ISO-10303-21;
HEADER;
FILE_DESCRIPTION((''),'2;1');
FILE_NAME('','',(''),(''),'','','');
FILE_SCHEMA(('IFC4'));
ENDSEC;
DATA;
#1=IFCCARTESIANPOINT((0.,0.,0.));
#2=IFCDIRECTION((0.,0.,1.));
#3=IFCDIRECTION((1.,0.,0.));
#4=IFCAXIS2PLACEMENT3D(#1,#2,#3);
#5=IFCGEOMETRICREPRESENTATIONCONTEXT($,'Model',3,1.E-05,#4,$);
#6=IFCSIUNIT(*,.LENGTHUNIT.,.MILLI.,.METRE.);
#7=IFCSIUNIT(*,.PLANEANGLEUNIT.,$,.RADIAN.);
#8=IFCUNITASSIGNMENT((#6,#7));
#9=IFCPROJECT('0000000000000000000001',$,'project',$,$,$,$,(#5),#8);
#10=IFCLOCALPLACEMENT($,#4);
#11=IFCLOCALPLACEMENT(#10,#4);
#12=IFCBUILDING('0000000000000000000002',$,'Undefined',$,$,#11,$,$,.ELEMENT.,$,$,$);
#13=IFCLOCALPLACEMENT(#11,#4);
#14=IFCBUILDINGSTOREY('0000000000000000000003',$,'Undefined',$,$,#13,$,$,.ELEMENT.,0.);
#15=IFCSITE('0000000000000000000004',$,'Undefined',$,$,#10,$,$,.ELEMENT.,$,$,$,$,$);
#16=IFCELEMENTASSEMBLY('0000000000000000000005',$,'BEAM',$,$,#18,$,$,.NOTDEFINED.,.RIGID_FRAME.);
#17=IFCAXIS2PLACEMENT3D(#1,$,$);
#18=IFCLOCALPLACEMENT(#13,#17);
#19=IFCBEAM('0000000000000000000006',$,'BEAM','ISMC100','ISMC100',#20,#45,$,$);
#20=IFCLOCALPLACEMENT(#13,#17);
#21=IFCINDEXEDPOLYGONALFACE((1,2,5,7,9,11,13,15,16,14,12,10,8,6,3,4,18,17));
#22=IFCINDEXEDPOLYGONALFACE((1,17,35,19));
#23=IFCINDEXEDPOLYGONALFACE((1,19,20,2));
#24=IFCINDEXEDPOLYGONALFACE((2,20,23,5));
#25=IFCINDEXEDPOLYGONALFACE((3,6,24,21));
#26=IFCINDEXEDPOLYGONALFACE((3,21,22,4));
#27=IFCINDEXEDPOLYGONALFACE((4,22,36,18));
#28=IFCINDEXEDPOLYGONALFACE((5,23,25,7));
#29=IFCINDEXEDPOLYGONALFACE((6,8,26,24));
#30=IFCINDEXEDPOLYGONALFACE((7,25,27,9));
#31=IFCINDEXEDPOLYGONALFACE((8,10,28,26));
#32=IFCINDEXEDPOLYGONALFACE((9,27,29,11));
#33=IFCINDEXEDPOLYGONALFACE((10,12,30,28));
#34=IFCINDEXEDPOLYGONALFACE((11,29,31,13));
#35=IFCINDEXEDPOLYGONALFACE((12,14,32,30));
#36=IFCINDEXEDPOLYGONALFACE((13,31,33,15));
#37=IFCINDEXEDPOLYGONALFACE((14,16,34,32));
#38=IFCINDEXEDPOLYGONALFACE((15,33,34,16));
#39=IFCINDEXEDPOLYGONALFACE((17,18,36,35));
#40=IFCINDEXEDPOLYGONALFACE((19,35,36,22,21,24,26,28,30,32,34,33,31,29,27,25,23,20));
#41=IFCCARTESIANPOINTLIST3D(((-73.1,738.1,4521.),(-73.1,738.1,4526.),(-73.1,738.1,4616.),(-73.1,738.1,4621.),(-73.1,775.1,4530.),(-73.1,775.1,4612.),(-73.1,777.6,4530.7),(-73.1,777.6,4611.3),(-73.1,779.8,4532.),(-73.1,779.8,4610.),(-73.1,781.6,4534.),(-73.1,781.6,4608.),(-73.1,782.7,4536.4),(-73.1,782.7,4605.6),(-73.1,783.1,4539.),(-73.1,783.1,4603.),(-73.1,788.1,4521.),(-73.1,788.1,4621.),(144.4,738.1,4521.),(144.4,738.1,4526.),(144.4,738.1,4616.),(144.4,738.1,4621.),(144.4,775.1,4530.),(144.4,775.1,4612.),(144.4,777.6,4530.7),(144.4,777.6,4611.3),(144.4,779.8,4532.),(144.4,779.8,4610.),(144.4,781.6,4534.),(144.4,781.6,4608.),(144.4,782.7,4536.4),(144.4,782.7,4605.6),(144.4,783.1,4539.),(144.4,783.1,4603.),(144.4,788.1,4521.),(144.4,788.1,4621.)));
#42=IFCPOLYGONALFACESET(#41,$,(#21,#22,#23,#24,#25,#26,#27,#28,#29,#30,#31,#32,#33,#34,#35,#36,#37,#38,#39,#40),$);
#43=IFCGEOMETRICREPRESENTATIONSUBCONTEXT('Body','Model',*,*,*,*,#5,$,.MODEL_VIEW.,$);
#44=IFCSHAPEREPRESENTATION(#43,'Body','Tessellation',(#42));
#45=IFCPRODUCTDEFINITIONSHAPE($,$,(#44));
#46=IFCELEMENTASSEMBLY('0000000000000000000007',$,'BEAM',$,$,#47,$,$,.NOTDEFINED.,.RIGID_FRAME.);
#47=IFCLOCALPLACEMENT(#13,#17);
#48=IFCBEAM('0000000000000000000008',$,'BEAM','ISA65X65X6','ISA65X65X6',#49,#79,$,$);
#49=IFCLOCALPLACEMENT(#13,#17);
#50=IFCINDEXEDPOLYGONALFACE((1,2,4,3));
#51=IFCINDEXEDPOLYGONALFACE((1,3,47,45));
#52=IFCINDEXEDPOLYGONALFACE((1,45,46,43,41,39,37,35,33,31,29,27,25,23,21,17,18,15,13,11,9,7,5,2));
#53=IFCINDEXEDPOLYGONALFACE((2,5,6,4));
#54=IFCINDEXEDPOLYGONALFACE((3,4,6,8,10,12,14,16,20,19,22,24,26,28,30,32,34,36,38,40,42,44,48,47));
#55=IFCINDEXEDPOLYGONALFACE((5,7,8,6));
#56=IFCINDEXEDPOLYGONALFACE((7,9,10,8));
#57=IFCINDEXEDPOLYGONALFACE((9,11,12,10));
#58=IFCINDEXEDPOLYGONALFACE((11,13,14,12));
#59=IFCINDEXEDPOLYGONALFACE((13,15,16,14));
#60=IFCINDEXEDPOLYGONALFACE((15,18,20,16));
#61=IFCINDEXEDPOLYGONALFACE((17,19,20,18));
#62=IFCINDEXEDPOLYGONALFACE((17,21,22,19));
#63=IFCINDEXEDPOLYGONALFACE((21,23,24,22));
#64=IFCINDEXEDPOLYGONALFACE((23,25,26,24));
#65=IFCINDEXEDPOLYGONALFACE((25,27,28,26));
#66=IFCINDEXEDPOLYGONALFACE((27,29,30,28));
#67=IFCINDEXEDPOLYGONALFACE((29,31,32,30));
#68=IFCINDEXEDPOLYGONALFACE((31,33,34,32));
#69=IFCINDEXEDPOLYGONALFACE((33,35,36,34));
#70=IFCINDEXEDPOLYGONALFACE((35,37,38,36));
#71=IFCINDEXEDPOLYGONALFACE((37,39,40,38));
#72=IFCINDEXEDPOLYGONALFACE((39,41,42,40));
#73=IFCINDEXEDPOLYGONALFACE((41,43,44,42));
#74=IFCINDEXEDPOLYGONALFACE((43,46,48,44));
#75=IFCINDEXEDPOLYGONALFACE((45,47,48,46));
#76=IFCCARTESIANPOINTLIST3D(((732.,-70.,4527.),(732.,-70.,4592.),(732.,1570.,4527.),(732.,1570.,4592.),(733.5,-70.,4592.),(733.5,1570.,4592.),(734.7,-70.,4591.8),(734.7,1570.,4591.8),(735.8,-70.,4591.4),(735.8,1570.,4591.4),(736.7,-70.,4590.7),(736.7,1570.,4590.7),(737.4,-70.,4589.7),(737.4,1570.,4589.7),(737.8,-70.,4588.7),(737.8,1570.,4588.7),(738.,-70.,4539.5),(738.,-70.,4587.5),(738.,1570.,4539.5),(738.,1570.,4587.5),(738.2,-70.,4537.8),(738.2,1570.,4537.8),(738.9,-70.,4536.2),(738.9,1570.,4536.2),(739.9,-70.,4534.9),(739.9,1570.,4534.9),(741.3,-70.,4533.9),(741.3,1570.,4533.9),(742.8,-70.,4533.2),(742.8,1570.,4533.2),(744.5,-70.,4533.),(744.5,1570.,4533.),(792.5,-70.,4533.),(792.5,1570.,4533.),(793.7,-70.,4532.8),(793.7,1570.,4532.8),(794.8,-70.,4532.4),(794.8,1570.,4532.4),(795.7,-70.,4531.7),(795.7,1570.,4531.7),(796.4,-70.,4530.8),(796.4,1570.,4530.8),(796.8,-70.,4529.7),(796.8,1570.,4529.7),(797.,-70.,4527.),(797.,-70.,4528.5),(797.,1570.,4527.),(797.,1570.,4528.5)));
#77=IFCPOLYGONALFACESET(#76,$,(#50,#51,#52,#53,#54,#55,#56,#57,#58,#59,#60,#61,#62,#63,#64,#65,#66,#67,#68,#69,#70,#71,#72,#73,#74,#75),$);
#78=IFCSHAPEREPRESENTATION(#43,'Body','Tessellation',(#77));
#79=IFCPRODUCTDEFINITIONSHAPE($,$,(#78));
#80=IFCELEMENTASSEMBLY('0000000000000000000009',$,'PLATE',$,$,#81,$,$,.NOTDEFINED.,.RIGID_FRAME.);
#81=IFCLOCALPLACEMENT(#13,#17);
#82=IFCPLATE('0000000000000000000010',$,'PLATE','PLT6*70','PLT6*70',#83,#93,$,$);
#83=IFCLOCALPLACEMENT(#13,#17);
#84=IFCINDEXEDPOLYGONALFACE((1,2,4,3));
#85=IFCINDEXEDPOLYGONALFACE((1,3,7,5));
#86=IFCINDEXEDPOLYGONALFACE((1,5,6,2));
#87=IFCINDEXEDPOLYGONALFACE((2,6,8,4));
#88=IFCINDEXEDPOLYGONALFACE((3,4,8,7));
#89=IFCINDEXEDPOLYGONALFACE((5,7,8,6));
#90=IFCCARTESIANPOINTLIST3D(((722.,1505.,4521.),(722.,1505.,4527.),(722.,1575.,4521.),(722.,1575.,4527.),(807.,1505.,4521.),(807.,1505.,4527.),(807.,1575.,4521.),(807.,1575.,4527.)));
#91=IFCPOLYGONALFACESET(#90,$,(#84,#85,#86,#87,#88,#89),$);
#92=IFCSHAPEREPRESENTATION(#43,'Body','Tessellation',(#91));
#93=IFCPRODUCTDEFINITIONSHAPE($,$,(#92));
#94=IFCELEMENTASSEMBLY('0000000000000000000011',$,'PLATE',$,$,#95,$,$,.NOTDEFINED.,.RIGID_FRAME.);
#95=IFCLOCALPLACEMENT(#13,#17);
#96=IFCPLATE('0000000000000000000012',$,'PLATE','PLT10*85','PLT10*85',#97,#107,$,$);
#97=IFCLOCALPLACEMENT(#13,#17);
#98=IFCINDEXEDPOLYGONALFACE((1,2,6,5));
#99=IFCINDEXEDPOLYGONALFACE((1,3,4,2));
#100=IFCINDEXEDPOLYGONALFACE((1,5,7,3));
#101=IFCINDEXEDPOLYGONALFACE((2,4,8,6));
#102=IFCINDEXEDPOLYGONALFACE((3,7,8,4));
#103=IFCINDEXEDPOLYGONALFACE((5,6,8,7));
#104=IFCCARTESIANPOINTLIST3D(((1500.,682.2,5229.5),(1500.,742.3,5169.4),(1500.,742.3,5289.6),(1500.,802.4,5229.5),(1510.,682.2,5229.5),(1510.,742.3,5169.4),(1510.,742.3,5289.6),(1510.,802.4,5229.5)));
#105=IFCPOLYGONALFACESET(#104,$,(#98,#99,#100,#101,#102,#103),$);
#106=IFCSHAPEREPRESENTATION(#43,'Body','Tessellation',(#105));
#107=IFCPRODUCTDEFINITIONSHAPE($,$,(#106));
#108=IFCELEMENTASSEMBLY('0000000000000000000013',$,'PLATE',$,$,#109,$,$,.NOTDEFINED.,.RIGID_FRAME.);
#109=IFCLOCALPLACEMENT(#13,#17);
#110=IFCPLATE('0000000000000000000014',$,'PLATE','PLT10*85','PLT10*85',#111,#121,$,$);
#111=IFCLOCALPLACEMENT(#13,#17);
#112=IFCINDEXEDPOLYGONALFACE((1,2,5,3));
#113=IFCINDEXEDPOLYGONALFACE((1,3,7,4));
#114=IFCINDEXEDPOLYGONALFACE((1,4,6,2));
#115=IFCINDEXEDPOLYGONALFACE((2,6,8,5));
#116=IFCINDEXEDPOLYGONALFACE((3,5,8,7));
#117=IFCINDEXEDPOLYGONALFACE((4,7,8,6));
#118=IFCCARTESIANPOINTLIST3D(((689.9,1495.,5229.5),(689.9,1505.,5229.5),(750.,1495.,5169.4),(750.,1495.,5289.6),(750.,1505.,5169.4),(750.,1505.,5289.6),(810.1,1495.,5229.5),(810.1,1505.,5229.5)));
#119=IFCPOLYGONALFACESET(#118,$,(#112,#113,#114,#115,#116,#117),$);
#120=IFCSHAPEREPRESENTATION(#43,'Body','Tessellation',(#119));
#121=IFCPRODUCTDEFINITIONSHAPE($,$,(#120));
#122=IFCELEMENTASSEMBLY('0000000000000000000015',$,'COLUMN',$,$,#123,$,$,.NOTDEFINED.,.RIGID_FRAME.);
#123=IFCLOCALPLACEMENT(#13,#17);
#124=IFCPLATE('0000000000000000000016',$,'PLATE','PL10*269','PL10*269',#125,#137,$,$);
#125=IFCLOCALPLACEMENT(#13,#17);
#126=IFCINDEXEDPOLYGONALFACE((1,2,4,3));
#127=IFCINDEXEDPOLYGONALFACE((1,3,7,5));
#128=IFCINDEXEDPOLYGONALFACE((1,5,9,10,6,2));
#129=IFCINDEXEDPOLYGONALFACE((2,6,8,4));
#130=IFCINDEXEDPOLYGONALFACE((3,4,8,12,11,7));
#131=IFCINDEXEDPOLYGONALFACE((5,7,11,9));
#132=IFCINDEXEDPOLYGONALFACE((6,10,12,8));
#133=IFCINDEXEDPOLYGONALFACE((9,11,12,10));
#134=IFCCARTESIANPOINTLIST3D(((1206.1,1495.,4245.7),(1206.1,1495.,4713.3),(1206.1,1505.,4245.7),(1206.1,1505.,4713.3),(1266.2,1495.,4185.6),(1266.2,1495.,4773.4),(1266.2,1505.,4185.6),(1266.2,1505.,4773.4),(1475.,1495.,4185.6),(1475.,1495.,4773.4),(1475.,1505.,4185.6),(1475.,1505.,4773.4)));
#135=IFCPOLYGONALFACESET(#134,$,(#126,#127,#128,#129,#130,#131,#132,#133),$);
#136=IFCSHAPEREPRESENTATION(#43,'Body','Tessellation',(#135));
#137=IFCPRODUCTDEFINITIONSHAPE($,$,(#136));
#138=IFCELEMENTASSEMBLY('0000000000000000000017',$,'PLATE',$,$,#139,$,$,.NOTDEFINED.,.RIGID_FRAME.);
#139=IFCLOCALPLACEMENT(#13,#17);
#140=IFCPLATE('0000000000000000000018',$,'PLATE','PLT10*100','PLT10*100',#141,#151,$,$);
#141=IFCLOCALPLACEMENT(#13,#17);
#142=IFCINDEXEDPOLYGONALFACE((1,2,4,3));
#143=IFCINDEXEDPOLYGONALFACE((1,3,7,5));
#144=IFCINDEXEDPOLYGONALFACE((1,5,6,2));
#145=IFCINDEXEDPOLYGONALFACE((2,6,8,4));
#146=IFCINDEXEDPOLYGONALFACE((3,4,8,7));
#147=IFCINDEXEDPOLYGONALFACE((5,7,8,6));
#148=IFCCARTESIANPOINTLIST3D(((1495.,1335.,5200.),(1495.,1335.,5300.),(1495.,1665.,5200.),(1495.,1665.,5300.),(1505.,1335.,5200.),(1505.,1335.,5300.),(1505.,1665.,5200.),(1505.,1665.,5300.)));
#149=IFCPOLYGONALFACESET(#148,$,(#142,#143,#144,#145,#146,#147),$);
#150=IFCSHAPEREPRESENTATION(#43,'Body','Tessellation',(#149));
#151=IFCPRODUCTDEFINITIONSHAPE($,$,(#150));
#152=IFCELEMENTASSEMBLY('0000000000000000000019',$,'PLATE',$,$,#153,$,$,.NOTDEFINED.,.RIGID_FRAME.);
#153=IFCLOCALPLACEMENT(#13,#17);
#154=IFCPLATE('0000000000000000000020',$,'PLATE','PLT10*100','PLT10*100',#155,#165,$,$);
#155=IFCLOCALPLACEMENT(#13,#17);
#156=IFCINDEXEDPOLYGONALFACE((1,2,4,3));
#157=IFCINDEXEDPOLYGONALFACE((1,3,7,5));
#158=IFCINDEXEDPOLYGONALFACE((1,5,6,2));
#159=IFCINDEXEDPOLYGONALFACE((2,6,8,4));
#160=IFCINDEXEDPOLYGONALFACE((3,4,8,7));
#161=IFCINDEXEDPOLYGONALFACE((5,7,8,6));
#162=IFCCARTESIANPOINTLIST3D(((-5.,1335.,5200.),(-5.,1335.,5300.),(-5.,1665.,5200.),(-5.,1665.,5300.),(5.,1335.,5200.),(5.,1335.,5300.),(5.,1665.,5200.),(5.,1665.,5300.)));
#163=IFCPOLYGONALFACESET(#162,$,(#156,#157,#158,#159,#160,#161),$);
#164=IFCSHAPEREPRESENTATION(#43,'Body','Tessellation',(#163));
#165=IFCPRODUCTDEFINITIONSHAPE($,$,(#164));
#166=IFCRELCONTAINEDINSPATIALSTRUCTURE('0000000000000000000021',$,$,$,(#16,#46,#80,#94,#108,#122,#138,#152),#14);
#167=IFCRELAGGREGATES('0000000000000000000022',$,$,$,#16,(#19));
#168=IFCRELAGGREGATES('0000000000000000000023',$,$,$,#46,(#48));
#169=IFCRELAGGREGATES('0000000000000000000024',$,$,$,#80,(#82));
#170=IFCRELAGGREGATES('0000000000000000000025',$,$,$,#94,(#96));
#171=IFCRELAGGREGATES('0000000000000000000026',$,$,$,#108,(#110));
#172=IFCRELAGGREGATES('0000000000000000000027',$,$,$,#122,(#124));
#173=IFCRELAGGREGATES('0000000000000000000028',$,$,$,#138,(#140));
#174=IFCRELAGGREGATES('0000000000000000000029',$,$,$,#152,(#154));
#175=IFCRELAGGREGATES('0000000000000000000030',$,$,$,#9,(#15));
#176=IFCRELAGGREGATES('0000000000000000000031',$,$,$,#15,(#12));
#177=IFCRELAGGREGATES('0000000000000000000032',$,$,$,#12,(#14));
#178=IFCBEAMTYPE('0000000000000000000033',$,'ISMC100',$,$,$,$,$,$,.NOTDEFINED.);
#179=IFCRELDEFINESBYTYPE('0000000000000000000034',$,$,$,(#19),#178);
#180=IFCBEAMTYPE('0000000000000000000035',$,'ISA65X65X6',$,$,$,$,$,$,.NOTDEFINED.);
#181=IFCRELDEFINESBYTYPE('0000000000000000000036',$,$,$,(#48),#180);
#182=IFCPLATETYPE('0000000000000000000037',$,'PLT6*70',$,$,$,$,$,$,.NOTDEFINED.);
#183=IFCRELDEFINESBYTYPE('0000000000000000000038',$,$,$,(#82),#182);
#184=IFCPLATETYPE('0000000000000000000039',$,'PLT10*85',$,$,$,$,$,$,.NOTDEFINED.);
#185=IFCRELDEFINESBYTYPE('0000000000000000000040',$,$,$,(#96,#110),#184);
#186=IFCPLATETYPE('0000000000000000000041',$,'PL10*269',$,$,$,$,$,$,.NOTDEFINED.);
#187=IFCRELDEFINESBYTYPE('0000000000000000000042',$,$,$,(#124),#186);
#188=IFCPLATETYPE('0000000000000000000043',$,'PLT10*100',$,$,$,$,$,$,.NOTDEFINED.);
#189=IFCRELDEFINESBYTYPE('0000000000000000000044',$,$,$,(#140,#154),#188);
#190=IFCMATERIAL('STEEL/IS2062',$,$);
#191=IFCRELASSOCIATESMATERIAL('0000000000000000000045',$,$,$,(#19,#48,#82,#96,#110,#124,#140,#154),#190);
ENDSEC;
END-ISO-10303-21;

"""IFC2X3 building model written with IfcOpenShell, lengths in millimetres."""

from ifc_helpers import new_model, si_unit, frame, origin_with_axes, origin_2d_with_axis, place, context, subcontext, project, spatial, polyline, l_section, u_section, outline, extrude, material, type_object, element, aggregate, save


model = new_model("IFC2X3")

# Units and contexts
model_context = context("Model", 3, precision=1e-05, world=origin_with_axes())
body_context = subcontext(model_context, "Body", "Model", "MODEL_VIEW")
ifc_project = project(units=[si_unit("LENGTHUNIT", "METRE", prefix="MILLI"), si_unit("PLANEANGLEUNIT", "RADIAN")], contexts=[model_context])

# Site, building, storey
site_placement = place(None, origin_with_axes())
site = spatial("IfcSite", under=ifc_project, at=site_placement, Name="Undefined", CompositionType="ELEMENT")
building_placement = place(site_placement, origin_with_axes())
building = spatial("IfcBuilding", under=site, at=building_placement, Name="Undefined", CompositionType="ELEMENT")
storey_placement = place(building_placement, origin_with_axes())
storey = spatial("IfcBuildingStorey", under=building, at=storey_placement, Name="Undefined", CompositionType="ELEMENT", Elevation=0.0)

# Shared definitions
ifc_material = material(Name="STEEL/IS2062")

# Element assemblies, beams
beam_type_1 = type_object("IfcBeamType", Name="ISMC100", PredefinedType="NOTDEFINED")
assembly_1_placement = place(storey_placement, origin_with_axes())
assembly_1 = element("IfcElementAssembly", 1, at=assembly_1_placement, inside=storey, Name="BEAM", AssemblyPlace="NOTDEFINED", PredefinedType="RIGID_FRAME")
beam_1_placement = place(assembly_1_placement, frame((144.4, 763.1, 4571.0), z_axis=(0.0, 0.0, -1.0), x_axis=(-1.0, 0.0, 0.0)))
beam_1 = element("IfcBeam", 2, at=beam_1_placement, type_object=beam_type_1, material=ifc_material, Name="BEAM", Description="ISMC100", ObjectType="ISMC100", context=body_context, shape_type="SweptSolid", body=[
    extrude(u_section(Depth=100.0, FlangeWidth=50.0, WebThickness=5.0, FlangeThickness=7.7, FilletRadius=9.0, FlangeSlope=0.10956, at=origin_2d_with_axis()), frame((217.6, 0.0, 0.0), z_axis=(-1.0, 0.0, 0.0), x_axis=(0.0, -1.0, 0.0)), (0.0, 0.0, 1.0), 217.6),
])
aggregate(assembly_1, [beam_1])
assembly_2_placement = place(storey_placement, origin_with_axes())
assembly_2 = element("IfcElementAssembly", 3, at=assembly_2_placement, inside=storey, Name="BEAM", AssemblyPlace="NOTDEFINED", PredefinedType="RIGID_FRAME")
beam_type_2 = type_object("IfcBeamType", Name="ISA65X65X6", PredefinedType="NOTDEFINED")
beam_2_placement = place(assembly_2_placement, frame((764.5, 1570.0, 4559.5), z_axis=(1.0, 0.0, 0.0), x_axis=(0.0, -1.0, 0.0)))
beam_2 = element("IfcBeam", 4, at=beam_2_placement, type_object=beam_type_2, material=ifc_material, Name="BEAM", Description="ISA65X65X6", ObjectType="ISA65X65X6", context=body_context, shape_type="SweptSolid", body=[
    extrude(l_section(Depth=65.0, Width=65.0, Thickness=6.0, FilletRadius=6.5, EdgeRadius=4.5, at=origin_2d_with_axis()), frame((1640.0, 0.0, 0.0), z_axis=(-1.0, 0.0, 0.0), x_axis=(0.0, -1.0, 0.0)), (0.0, 0.0, 1.0), 1640.0),
])
aggregate(assembly_2, [beam_2])

# Element assemblies, plates
assembly_3_placement = place(storey_placement, origin_with_axes())
assembly_3 = element("IfcElementAssembly", 5, at=assembly_3_placement, inside=storey, Name="PLATE", AssemblyPlace="NOTDEFINED", PredefinedType="RIGID_FRAME")
plate_type_1 = type_object("IfcPlateType", Name="PLT6*70", PredefinedType="NOTDEFINED")
plate_1_placement = place(assembly_3_placement, frame((807.0, 1575.0, 4524.0), z_axis=(0.0, 0.0, 1.0), x_axis=(-1.0, 0.0, 0.0)))
plate_1 = element("IfcPlate", 6, at=plate_1_placement, type_object=plate_type_1, material=ifc_material, Name="PLATE", Description="PLT6*70", ObjectType="PLT6*70", context=body_context, shape_type="SweptSolid", body=[
    extrude(outline(polyline([(0.0, 0.0), (85.0, 0.0), (85.0, 70.0), (0.0, 70.0), (0.0, 0.0)])), frame((0.0, 0.0, -3.0), z_axis=(0.0, 0.0, 1.0), x_axis=(1.0, 0.0, 0.0)), (0.0, 0.0, 1.0), 6.0),
])
aggregate(assembly_3, [plate_1])
assembly_4_placement = place(storey_placement, origin_with_axes())
assembly_4 = element("IfcElementAssembly", 7, at=assembly_4_placement, inside=storey, Name="PLATE", AssemblyPlace="NOTDEFINED", PredefinedType="RIGID_FRAME")
plate_type_2 = type_object("IfcPlateType", Name="PLT10*85", PredefinedType="NOTDEFINED")
plate_2_placement = place(assembly_4_placement, frame((1505.0, 742.3, 5289.6), z_axis=(1.0, 0.0, 0.0), x_axis=(0.0, -0.707107, -0.707107)))
plate_2 = element("IfcPlate", 8, at=plate_2_placement, type_object=plate_type_2, material=ifc_material, Name="PLATE", Description="PLT10*85", ObjectType="PLT10*85", context=body_context, shape_type="SweptSolid", body=[
    extrude(outline(polyline([(0.0, 0.0), (85.0, 0.0), (85.0, 85.0), (0.0, 85.0), (0.0, 0.0)])), frame((0.0, 0.0, -5.0), z_axis=(0.0, 0.0, 1.0), x_axis=(1.0, 0.0, 0.0)), (0.0, 0.0, 1.0), 10.0),
])
aggregate(assembly_4, [plate_2])
assembly_5_placement = place(storey_placement, origin_with_axes())
assembly_5 = element("IfcElementAssembly", 9, at=assembly_5_placement, inside=storey, Name="PLATE", AssemblyPlace="NOTDEFINED", PredefinedType="RIGID_FRAME")
plate_3_placement = place(assembly_5_placement, frame((750.0, 1500.0, 5289.6), z_axis=(0.0, -1.0, 0.0), x_axis=(-0.707107, 0.0, -0.707107)))
plate_3 = element("IfcPlate", 10, at=plate_3_placement, type_object=plate_type_2, material=ifc_material, Name="PLATE", Description="PLT10*85", ObjectType="PLT10*85", context=body_context, shape_type="SweptSolid", body=[
    extrude(outline(polyline([(0.0, 0.0), (85.0, 0.0), (85.0, 85.0), (0.0, 85.0), (0.0, 0.0)])), frame((0.0, 0.0, -5.0), z_axis=(0.0, 0.0, 1.0), x_axis=(1.0, 0.0, 0.0)), (0.0, 0.0, 1.0), 10.0),
])
aggregate(assembly_5, [plate_3])
assembly_6_placement = place(storey_placement, origin_with_axes())
assembly_6 = element("IfcElementAssembly", 11, at=assembly_6_placement, inside=storey, Name="COLUMN", AssemblyPlace="NOTDEFINED", PredefinedType="RIGID_FRAME")
plate_type_3 = type_object("IfcPlateType", Name="PL10*269", PredefinedType="NOTDEFINED")
plate_4_placement = place(assembly_6_placement, frame((1475.0, 1500.0, 4773.4), z_axis=(0.0, 1.0, 0.0), x_axis=(0.0, 0.0, -1.0)))
plate_4 = element("IfcPlate", 12, at=plate_4_placement, type_object=plate_type_3, material=ifc_material, Name="PLATE", Description="PL10*269", ObjectType="PL10*269", context=body_context, shape_type="SweptSolid", body=[
    extrude(outline(polyline([(0.0, 0.0), (587.8, 0.0), (587.8, 208.8), (527.7, 268.9), (60.1, 268.9), (0.0, 208.8), (0.0, 0.0)])), frame((0.0, 0.0, -5.0), z_axis=(0.0, 0.0, 1.0), x_axis=(1.0, 0.0, 0.0)), (0.0, 0.0, 1.0), 10.0),
])
aggregate(assembly_6, [plate_4])
assembly_7_placement = place(storey_placement, origin_with_axes())
assembly_7 = element("IfcElementAssembly", 13, at=assembly_7_placement, inside=storey, Name="PLATE", AssemblyPlace="NOTDEFINED", PredefinedType="RIGID_FRAME")
plate_type_4 = type_object("IfcPlateType", Name="PLT10*100", PredefinedType="NOTDEFINED")
plate_5_placement = place(assembly_7_placement, frame((1500.0, 1665.0, 5300.0), z_axis=(-1.0, 0.0, 0.0), x_axis=(0.0, 0.0, -1.0)))
plate_5 = element("IfcPlate", 14, at=plate_5_placement, type_object=plate_type_4, material=ifc_material, Name="PLATE", Description="PLT10*100", ObjectType="PLT10*100", context=body_context, shape_type="SweptSolid", body=[
    extrude(outline(polyline([(0.0, 0.0), (100.0, 0.0), (100.0, 330.0), (0.0, 330.0), (0.0, 0.0)])), frame((0.0, 0.0, -5.0), z_axis=(0.0, 0.0, 1.0), x_axis=(1.0, 0.0, 0.0)), (0.0, 0.0, 1.0), 10.0),
])
aggregate(assembly_7, [plate_5])
assembly_8_placement = place(storey_placement, origin_with_axes())
assembly_8 = element("IfcElementAssembly", 15, at=assembly_8_placement, inside=storey, Name="PLATE", AssemblyPlace="NOTDEFINED", PredefinedType="RIGID_FRAME")
plate_6_placement = place(assembly_8_placement, frame((0.0, 1665.0, 5300.0), z_axis=(-1.0, 0.0, 0.0), x_axis=(0.0, 0.0, -1.0)))
plate_6 = element("IfcPlate", 16, at=plate_6_placement, type_object=plate_type_4, material=ifc_material, Name="PLATE", Description="PLT10*100", ObjectType="PLT10*100", context=body_context, shape_type="SweptSolid", body=[
    extrude(outline(polyline([(0.0, 0.0), (100.0, 0.0), (100.0, 330.0), (0.0, 330.0), (0.0, 0.0)])), frame((0.0, 0.0, -5.0), z_axis=(0.0, 0.0, 1.0), x_axis=(1.0, 0.0, 0.0)), (0.0, 0.0, 1.0), 10.0),
])
aggregate(assembly_8, [plate_6])

save(model, "model.ifc")
